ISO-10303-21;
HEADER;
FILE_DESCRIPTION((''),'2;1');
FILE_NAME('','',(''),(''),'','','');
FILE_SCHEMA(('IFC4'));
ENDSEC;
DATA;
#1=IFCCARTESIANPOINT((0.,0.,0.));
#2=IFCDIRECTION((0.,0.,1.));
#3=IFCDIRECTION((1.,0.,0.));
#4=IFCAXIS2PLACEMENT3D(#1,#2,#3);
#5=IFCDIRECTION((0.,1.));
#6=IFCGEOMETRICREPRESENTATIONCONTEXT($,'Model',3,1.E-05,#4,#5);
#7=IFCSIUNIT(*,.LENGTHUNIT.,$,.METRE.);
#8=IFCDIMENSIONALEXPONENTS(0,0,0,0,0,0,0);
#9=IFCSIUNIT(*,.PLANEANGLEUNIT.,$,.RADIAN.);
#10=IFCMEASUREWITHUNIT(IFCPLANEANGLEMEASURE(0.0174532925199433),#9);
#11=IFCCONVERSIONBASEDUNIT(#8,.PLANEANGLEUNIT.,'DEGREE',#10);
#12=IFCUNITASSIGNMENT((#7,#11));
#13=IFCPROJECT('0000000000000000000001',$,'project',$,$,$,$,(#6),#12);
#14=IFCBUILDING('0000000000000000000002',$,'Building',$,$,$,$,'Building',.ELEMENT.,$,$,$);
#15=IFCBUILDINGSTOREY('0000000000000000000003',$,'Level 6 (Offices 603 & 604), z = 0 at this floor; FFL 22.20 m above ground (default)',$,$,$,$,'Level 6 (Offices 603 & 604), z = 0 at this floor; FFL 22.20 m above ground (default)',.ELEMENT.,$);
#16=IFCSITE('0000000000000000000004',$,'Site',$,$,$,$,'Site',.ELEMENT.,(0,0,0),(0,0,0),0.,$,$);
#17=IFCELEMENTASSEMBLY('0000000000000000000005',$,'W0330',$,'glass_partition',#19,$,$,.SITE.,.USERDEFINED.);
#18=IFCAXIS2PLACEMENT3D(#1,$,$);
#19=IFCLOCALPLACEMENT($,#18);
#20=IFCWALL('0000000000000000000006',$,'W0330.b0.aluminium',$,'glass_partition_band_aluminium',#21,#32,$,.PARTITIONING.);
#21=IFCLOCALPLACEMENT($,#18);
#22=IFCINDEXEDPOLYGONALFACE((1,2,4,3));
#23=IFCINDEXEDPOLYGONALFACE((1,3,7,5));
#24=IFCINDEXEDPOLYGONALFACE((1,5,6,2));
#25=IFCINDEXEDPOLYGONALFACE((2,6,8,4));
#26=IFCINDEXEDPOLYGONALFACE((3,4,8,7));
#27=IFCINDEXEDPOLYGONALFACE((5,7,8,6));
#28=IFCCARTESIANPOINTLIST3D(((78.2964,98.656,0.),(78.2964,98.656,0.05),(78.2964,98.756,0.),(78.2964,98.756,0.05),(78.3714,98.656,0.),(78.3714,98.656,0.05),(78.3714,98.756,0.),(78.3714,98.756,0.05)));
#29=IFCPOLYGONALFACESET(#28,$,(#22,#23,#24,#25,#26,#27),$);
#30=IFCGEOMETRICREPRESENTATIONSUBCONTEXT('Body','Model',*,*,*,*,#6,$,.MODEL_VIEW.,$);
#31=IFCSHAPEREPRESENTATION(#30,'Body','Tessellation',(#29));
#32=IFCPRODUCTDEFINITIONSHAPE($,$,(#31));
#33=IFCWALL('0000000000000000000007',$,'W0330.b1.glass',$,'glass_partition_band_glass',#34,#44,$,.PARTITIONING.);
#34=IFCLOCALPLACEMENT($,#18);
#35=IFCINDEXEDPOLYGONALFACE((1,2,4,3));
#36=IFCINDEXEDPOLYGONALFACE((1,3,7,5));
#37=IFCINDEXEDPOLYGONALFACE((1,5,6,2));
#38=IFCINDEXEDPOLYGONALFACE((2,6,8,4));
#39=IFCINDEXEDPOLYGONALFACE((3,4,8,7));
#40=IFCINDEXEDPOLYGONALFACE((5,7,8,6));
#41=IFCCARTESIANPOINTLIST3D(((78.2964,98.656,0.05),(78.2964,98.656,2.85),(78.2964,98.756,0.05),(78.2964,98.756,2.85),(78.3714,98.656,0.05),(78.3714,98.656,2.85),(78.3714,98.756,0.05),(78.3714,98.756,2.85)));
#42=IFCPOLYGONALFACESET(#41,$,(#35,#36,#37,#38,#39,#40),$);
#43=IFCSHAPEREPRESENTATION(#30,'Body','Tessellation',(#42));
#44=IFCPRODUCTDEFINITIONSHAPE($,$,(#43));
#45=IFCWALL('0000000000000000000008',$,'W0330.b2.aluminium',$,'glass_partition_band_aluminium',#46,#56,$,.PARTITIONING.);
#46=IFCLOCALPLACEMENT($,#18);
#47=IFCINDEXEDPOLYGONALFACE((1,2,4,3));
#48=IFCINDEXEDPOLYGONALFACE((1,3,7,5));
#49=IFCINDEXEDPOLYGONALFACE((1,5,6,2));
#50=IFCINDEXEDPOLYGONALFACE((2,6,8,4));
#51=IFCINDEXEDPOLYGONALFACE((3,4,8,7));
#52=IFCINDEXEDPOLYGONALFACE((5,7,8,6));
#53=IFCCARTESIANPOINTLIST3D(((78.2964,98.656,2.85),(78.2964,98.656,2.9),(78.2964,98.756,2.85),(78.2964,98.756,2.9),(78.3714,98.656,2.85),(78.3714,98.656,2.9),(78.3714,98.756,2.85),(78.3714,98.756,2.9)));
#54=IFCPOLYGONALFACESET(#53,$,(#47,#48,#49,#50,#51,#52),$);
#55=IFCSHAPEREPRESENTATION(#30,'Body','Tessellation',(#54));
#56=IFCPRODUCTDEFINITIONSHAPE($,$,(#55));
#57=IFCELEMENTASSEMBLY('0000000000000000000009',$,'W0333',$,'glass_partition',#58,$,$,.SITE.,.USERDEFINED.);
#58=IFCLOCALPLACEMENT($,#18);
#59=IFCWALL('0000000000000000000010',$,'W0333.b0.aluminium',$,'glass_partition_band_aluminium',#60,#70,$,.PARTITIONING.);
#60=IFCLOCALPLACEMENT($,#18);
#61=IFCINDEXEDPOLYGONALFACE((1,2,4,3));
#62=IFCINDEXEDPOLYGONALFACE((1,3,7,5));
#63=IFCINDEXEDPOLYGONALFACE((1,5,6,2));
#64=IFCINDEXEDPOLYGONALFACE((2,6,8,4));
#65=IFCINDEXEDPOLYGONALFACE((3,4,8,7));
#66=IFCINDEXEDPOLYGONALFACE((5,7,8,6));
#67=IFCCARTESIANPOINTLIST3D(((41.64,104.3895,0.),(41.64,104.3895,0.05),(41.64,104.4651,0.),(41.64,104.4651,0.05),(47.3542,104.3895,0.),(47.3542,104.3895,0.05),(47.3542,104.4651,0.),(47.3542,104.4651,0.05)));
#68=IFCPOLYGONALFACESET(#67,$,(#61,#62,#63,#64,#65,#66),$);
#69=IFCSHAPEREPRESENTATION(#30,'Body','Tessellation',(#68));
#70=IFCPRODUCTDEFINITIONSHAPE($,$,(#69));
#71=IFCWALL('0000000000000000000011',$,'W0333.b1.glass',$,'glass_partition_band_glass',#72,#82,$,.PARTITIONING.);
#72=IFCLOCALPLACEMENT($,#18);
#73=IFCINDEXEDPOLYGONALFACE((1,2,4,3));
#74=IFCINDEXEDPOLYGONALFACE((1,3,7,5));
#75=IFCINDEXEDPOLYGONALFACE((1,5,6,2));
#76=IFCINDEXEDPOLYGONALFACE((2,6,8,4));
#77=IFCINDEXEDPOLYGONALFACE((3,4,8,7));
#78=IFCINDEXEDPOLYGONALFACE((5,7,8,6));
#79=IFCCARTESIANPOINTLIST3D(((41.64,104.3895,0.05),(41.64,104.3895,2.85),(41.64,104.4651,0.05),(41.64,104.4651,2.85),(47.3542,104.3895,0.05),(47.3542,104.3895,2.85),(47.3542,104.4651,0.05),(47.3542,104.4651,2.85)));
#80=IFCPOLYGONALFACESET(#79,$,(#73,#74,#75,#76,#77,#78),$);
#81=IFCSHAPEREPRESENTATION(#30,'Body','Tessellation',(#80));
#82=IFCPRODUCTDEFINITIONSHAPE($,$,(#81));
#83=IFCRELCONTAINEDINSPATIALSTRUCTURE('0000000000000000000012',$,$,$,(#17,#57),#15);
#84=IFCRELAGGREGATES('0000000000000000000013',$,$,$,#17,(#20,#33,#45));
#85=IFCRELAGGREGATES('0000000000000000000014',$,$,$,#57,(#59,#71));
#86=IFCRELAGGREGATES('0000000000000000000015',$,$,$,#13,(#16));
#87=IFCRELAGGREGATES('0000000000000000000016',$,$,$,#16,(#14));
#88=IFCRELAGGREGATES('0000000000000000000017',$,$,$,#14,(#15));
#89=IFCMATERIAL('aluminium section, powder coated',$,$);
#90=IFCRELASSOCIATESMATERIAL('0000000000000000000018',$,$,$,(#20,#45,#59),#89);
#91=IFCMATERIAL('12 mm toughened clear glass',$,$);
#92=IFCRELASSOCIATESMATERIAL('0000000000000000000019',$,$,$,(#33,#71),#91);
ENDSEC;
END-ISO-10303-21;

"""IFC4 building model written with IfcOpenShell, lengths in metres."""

from ifc_helpers import new_model, entity, si_unit, converted_unit, direction, frame, frame_2d, origin_with_axes, place, context, subcontext, project, spatial, rectangle, extrude, material, element, aggregate, save


model = new_model("IFC4")

# Units and contexts
model_context = context("Model", 3, precision=1e-05, world=origin_with_axes(), true_north=direction((0.0, 1.0)))
body_context = subcontext(model_context, "Body", "Model", "MODEL_VIEW")
ifc_project = project(units=[si_unit("LENGTHUNIT", "METRE"), converted_unit("PLANEANGLEUNIT", "DEGREE", entity("IfcPlaneAngleMeasure", 0.0174532925199433), si_unit("PLANEANGLEUNIT", "RADIAN"), dimensions=[0, 0, 0, 0, 0, 0, 0])], contexts=[model_context])

# Site, building, storey
site = spatial("IfcSite", under=ifc_project, Name="Site", LongName="Site", CompositionType="ELEMENT", RefLatitude=(0, 0, 0), RefLongitude=(0, 0, 0), RefElevation=0.0)
building = spatial("IfcBuilding", under=site, Name="Building", LongName="Building", CompositionType="ELEMENT")
storey = spatial("IfcBuildingStorey", under=building, Name="Level 6 (Offices 603 & 604), z = 0 at this floor; FFL 22.20 m above ground (default)", LongName="Level 6 (Offices 603 & 604), z = 0 at this floor; FFL 22.20 m above ground (default)", CompositionType="ELEMENT")

# Shared definitions
placement = place(None, origin_with_axes())

# Shared definitions
ifc_material_1 = material(Name="12 mm toughened clear glass")

# Element assemblies, walls
ifc_material_2 = material(Name="aluminium section, powder coated")
assembly_1 = element("IfcElementAssembly", 1, inside=storey, Name="W0330", ObjectType="glass_partition", AssemblyPlace="SITE", PredefinedType="USERDEFINED")
wall_1 = element("IfcWall", 2, at=placement, material=ifc_material_2, Name="W0330.b0.aluminium", ObjectType="glass_partition_band_aluminium", PredefinedType="PARTITIONING", context=body_context, shape_type="SweptSolid", body=[
    extrude(rectangle(XDim=0.1, YDim=0.075, at=frame_2d((0.0, 0.0), x_axis=(0.0, 1.0))), frame((78.3339, 98.706, 0.0), z_axis=(0.0, 0.0, 1.0), x_axis=(1.0, 0.0, 0.0)), (0.0, 0.0, 1.0), 0.05),
])
wall_2 = element("IfcWall", 3, at=placement, material=ifc_material_1, Name="W0330.b1.glass", ObjectType="glass_partition_band_glass", PredefinedType="PARTITIONING", context=body_context, shape_type="SweptSolid", body=[
    extrude(rectangle(XDim=0.1, YDim=0.075, at=frame_2d((0.0, 0.0), x_axis=(0.0, 1.0))), frame((78.3339, 98.706, 0.05), z_axis=(0.0, 0.0, 1.0), x_axis=(1.0, 0.0, 0.0)), (0.0, 0.0, 1.0), 2.8),
])
wall_3 = element("IfcWall", 4, at=placement, material=ifc_material_2, Name="W0330.b2.aluminium", ObjectType="glass_partition_band_aluminium", PredefinedType="PARTITIONING", context=body_context, shape_type="SweptSolid", body=[
    extrude(rectangle(XDim=0.1, YDim=0.075, at=frame_2d((0.0, 0.0), x_axis=(0.0, 1.0))), frame((78.3339, 98.706, 2.85), z_axis=(0.0, 0.0, 1.0), x_axis=(1.0, 0.0, 0.0)), (0.0, 0.0, 1.0), 0.05),
])
aggregate(assembly_1, [wall_1, wall_2, wall_3])
assembly_2 = element("IfcElementAssembly", 5, inside=storey, Name="W0333", ObjectType="glass_partition", AssemblyPlace="SITE", PredefinedType="USERDEFINED")
wall_4 = element("IfcWall", 6, at=placement, material=ifc_material_2, Name="W0333.b0.aluminium", ObjectType="glass_partition_band_aluminium", PredefinedType="PARTITIONING", context=body_context, shape_type="SweptSolid", body=[
    extrude(rectangle(XDim=5.7142, YDim=0.0756, at=frame_2d((0.0, 0.0), x_axis=(1.0, 0.0))), frame((44.4971, 104.4273, 0.0), z_axis=(0.0, 0.0, 1.0), x_axis=(1.0, 0.0, 0.0)), (0.0, 0.0, 1.0), 0.05),
])
wall_5 = element("IfcWall", 7, at=placement, material=ifc_material_1, Name="W0333.b1.glass", ObjectType="glass_partition_band_glass", PredefinedType="PARTITIONING", context=body_context, shape_type="SweptSolid", body=[
    extrude(rectangle(XDim=5.7142, YDim=0.0756, at=frame_2d((0.0, 0.0), x_axis=(1.0, 0.0))), frame((44.4971, 104.4273, 0.05), z_axis=(0.0, 0.0, 1.0), x_axis=(1.0, 0.0, 0.0)), (0.0, 0.0, 1.0), 2.8),
])
aggregate(assembly_2, [wall_4, wall_5])

save(model, "model.ifc")
